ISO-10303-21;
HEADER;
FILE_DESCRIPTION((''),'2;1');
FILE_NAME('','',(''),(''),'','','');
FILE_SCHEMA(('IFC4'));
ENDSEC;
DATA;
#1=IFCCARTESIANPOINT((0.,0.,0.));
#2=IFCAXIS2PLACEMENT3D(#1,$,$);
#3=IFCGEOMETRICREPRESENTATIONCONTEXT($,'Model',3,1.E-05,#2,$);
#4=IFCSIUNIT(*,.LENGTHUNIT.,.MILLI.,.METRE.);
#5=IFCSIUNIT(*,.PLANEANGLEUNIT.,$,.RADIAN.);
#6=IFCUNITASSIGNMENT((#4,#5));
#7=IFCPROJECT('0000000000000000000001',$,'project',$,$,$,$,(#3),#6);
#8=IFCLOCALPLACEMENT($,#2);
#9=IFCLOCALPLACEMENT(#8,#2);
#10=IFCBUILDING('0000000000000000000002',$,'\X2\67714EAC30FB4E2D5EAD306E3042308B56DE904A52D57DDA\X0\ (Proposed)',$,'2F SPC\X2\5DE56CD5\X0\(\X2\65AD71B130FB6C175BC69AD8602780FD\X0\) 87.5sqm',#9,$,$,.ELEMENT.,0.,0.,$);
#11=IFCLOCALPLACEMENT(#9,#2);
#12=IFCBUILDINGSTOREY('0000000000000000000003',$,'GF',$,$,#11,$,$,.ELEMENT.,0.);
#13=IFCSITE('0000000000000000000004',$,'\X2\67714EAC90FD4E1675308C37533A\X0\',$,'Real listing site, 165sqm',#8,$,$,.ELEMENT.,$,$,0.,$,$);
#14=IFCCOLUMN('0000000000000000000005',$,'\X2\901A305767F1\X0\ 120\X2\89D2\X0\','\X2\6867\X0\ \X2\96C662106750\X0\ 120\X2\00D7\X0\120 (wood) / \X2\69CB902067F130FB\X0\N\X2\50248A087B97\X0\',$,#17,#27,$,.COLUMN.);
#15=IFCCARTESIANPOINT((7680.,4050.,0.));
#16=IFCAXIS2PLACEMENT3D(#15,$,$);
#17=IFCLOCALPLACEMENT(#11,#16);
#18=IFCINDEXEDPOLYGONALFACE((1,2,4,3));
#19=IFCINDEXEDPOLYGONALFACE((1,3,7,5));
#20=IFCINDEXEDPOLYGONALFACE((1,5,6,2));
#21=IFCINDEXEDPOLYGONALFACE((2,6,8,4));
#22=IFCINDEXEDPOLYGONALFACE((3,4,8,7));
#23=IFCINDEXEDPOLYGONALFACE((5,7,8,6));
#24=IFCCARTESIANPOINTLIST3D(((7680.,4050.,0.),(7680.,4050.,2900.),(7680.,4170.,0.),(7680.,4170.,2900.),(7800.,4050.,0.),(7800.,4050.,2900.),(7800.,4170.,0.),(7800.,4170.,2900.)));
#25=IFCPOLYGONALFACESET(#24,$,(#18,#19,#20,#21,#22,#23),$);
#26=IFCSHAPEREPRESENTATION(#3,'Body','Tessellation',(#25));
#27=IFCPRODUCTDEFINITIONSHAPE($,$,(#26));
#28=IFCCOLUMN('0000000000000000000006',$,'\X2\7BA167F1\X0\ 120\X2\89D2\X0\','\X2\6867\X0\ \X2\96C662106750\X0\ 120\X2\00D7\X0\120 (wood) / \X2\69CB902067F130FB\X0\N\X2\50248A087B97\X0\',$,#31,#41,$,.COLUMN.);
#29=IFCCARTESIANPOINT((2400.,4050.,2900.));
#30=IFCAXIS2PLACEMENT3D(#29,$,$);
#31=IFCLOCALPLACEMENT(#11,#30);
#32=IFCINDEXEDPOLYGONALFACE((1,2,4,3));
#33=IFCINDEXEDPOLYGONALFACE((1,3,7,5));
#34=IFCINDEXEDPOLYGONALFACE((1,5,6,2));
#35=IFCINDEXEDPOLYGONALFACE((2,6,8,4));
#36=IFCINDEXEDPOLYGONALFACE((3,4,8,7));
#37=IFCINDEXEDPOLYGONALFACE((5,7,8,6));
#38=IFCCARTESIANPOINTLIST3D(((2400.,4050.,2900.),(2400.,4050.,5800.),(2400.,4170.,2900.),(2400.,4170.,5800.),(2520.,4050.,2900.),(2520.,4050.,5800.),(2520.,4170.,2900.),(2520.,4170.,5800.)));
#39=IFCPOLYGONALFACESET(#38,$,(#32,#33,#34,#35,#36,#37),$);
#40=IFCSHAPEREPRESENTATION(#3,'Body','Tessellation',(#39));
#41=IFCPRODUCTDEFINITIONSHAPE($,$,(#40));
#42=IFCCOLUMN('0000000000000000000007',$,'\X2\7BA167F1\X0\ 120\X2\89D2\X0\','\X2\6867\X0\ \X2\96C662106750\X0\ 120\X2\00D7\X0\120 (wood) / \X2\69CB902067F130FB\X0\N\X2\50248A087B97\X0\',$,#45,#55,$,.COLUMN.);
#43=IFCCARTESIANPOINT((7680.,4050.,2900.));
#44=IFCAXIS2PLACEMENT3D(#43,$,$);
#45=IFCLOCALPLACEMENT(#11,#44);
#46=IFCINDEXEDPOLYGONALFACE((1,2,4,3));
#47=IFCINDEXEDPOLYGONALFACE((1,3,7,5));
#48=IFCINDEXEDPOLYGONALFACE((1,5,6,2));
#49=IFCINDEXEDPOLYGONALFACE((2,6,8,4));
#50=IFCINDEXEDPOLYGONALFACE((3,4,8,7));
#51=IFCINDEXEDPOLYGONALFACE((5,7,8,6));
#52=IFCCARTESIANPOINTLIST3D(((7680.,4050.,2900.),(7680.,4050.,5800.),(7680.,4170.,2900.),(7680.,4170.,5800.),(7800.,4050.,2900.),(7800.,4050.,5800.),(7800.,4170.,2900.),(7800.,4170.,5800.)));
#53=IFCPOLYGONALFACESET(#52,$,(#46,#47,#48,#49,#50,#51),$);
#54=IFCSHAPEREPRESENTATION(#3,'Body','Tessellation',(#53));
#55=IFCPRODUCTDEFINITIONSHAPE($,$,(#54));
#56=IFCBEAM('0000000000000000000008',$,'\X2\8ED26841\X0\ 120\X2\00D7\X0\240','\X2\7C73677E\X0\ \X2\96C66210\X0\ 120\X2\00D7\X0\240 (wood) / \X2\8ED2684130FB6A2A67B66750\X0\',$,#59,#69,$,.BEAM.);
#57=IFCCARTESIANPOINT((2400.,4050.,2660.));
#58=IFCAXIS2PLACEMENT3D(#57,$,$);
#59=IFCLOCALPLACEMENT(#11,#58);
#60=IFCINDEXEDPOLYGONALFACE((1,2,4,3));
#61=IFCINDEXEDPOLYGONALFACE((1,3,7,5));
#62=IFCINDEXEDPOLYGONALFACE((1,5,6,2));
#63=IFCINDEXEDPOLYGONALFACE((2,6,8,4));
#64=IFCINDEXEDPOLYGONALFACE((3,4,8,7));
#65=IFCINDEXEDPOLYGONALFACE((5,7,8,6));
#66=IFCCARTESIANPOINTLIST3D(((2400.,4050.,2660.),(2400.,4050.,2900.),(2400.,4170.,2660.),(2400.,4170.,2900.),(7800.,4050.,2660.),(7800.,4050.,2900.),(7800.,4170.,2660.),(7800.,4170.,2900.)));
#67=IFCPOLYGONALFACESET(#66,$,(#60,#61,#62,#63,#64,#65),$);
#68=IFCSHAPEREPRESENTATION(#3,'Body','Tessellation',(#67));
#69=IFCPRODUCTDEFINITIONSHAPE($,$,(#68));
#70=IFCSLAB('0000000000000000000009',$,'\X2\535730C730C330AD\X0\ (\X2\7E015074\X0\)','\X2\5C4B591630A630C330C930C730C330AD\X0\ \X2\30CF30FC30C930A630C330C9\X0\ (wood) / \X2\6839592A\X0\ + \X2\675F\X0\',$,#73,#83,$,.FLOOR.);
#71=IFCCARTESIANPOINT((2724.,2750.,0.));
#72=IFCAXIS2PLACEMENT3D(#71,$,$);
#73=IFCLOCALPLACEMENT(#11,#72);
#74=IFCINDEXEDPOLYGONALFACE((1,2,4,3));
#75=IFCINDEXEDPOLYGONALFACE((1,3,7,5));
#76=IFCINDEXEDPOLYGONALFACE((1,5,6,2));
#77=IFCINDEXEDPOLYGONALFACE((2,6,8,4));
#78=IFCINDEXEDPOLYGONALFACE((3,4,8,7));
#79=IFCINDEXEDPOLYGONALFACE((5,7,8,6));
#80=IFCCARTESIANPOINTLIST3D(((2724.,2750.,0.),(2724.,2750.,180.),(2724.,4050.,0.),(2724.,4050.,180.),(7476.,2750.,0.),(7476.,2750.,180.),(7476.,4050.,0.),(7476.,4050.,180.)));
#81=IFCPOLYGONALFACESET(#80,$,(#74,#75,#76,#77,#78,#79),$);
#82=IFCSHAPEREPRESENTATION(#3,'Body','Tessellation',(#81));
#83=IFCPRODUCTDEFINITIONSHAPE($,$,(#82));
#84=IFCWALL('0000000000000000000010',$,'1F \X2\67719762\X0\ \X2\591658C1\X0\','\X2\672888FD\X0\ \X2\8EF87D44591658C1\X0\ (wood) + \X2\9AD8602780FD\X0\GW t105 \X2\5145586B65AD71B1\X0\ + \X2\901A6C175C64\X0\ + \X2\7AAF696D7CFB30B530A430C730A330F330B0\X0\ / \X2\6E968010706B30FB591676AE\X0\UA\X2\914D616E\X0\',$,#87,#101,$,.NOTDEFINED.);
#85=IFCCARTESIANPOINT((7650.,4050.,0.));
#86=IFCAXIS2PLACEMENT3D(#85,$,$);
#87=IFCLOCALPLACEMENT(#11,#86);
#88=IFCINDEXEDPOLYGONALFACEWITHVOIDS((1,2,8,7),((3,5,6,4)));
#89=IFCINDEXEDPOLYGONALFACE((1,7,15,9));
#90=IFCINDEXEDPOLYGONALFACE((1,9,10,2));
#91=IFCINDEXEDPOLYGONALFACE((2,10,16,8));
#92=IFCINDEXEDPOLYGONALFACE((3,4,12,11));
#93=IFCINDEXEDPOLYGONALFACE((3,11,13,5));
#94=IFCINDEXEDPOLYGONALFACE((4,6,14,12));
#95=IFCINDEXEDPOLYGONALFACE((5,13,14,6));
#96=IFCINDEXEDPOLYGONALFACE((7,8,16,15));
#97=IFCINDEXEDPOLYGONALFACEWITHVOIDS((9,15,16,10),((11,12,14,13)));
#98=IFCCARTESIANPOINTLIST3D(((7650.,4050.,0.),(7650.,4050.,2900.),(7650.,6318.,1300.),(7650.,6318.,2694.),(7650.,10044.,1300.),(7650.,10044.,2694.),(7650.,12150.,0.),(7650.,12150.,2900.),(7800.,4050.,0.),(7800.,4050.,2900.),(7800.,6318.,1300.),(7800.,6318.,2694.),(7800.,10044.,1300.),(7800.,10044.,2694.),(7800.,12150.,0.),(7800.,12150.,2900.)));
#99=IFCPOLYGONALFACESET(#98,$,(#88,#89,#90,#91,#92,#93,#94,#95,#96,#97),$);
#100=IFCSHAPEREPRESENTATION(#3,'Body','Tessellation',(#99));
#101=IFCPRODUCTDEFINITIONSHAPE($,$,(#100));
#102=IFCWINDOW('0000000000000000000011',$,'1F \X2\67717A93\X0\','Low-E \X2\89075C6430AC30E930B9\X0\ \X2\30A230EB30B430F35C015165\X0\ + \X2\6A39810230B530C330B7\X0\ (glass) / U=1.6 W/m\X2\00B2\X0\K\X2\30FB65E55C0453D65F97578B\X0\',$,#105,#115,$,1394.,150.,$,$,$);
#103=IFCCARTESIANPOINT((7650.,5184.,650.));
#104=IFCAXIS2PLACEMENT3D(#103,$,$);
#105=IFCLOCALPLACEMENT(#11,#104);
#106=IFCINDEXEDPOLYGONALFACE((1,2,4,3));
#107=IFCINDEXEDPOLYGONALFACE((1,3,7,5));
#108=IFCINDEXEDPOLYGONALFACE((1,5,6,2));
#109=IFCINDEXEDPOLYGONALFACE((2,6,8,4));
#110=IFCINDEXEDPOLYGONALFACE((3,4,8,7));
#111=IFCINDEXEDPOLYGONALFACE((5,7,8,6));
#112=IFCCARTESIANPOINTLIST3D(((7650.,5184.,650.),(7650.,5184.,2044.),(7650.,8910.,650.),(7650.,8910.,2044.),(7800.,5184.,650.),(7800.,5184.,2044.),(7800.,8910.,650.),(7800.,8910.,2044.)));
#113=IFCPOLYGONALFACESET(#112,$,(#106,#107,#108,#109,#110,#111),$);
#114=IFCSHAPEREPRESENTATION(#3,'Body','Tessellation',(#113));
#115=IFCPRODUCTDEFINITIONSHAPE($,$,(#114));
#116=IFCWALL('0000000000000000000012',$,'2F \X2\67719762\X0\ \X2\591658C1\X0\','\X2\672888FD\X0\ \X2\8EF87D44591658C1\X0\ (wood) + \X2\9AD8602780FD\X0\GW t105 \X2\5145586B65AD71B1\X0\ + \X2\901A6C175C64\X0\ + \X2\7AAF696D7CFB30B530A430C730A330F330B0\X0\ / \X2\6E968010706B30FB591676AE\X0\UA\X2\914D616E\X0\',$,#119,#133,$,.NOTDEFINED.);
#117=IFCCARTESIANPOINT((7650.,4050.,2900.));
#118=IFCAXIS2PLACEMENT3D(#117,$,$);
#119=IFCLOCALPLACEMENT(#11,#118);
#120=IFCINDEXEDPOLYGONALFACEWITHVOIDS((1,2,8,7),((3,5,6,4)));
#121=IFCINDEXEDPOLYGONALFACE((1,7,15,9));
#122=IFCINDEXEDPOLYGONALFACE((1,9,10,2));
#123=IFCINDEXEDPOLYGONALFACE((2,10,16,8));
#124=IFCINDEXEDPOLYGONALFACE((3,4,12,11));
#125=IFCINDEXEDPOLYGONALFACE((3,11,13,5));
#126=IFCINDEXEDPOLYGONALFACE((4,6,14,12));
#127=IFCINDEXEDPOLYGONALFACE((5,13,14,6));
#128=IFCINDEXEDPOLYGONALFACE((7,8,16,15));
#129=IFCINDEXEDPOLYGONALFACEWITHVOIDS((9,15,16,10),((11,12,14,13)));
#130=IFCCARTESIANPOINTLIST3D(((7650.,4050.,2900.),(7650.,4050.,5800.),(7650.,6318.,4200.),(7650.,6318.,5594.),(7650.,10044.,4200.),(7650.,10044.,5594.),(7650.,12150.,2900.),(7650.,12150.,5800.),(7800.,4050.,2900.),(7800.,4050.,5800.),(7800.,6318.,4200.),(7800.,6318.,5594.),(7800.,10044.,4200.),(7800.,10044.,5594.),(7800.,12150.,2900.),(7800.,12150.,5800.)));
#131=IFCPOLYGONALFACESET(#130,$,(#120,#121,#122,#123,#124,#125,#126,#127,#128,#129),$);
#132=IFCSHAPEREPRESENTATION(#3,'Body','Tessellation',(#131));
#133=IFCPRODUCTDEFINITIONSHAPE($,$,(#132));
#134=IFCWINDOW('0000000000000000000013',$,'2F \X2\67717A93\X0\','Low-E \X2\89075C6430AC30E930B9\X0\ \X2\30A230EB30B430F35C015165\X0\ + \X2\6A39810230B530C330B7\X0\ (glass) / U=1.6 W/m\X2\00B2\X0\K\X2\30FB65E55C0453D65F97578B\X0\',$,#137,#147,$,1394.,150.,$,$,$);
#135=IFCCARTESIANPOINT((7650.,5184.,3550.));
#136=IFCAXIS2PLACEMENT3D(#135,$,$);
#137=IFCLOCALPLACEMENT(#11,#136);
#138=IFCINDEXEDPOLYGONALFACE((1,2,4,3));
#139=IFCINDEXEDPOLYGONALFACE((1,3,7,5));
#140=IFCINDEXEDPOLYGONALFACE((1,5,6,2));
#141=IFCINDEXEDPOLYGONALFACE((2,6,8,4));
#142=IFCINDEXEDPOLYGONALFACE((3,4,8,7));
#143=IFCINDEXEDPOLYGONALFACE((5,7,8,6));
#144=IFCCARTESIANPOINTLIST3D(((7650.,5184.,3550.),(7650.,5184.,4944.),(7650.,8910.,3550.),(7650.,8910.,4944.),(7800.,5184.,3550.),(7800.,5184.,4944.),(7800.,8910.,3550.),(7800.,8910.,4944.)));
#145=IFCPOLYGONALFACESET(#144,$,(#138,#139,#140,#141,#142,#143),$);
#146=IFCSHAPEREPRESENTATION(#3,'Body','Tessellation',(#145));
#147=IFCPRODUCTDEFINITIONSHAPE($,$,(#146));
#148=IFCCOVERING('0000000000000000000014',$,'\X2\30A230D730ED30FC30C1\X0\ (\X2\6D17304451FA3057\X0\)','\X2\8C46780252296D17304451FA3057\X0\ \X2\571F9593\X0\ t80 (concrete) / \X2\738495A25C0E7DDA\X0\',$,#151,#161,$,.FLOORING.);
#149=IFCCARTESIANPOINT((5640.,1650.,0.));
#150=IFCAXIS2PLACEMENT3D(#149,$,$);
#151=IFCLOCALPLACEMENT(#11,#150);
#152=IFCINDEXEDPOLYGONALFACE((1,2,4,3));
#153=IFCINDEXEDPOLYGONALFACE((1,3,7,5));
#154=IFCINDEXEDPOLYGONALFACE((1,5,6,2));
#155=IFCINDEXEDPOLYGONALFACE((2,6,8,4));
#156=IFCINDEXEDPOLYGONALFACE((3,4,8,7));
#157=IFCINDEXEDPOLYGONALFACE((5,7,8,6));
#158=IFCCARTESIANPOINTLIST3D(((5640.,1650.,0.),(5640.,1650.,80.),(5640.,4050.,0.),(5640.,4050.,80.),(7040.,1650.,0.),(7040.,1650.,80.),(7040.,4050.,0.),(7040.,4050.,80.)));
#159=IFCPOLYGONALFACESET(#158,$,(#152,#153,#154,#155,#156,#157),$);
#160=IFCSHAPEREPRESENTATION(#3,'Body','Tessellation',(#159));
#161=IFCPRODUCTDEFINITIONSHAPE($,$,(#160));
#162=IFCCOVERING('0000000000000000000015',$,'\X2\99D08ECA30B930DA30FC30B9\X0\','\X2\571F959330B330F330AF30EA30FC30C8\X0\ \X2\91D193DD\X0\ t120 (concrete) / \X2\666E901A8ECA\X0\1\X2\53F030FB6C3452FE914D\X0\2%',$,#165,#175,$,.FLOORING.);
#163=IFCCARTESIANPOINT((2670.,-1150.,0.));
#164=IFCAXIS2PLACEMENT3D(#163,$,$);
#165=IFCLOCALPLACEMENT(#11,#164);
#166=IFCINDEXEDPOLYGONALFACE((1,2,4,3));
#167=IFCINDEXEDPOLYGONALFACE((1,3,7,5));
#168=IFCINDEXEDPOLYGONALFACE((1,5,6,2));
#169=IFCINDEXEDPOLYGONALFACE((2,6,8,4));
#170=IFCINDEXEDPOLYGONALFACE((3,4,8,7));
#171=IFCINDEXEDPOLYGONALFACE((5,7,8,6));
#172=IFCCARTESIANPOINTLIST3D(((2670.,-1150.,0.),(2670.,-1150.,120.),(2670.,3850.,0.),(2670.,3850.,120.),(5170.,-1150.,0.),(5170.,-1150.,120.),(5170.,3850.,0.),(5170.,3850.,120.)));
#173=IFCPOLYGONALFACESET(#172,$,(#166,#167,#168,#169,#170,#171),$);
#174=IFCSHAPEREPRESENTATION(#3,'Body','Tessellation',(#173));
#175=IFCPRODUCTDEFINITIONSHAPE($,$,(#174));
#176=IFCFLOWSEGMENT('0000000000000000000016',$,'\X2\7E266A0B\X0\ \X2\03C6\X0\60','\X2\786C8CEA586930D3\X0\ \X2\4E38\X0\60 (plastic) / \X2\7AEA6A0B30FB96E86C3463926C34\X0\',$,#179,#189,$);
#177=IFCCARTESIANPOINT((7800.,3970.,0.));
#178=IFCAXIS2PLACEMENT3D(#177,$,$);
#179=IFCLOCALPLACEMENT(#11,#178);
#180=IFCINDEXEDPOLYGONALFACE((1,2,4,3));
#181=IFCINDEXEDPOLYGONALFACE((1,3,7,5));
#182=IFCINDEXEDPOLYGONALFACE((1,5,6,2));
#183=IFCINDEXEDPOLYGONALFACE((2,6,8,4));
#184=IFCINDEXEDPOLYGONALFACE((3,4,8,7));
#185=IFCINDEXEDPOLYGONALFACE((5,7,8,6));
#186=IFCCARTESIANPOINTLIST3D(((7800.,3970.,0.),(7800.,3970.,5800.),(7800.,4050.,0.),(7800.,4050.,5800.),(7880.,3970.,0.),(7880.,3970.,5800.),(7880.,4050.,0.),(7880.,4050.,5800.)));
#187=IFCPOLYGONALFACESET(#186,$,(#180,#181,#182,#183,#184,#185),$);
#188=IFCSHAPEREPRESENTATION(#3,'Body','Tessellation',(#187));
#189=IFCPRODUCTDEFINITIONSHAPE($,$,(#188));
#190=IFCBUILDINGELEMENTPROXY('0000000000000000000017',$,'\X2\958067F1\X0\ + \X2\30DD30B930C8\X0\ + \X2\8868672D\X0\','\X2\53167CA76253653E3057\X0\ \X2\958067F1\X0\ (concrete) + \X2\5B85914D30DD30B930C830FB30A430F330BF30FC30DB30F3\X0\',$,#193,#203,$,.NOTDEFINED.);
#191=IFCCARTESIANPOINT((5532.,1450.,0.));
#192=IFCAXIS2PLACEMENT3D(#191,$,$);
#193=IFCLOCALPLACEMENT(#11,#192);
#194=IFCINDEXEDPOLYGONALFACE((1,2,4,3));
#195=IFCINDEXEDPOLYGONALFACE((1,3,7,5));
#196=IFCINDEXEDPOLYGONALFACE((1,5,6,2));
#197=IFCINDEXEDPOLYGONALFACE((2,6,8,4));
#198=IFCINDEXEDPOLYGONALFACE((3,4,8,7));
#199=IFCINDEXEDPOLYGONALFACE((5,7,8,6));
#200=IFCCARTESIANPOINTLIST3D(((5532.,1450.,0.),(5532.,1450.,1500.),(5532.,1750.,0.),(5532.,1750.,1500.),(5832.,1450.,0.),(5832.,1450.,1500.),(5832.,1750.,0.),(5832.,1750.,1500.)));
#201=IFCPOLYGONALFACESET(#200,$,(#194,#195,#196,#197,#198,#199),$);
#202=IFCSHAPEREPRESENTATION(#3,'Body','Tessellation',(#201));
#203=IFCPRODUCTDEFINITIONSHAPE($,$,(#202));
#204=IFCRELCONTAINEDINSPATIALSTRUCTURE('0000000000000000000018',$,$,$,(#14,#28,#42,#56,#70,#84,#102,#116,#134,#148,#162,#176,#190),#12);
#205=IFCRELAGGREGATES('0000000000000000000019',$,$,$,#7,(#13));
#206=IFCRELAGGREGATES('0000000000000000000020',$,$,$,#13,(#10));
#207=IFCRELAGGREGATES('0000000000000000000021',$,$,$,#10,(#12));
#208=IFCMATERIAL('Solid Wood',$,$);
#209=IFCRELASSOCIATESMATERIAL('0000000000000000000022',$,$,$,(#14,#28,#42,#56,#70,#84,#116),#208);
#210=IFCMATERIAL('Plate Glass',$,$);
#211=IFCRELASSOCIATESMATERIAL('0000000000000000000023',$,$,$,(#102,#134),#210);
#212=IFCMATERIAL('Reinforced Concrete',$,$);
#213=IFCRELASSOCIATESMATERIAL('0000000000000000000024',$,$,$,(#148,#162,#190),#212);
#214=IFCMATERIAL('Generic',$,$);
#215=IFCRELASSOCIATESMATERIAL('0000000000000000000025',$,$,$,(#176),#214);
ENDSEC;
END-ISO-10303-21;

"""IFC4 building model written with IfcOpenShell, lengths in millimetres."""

from ifc_helpers import new_model, si_unit, frame, frame_2d, origin, place, context, project, spatial, rectangle, extrude, material, element, fill, save


model = new_model("IFC4")

# Units and contexts
model_context = context("Model", 3, precision=1e-05, world=origin())
ifc_project = project(units=[si_unit("LENGTHUNIT", "METRE", prefix="MILLI"), si_unit("PLANEANGLEUNIT", "RADIAN")], contexts=[model_context])

# Site, building, storey
site_placement = place(None, origin())
site = spatial("IfcSite", under=ifc_project, at=site_placement, Name="東京都世田谷区", ObjectType="Real listing site, 165sqm", CompositionType="ELEMENT", RefElevation=0.0)
building_placement = place(site_placement, origin())
building = spatial("IfcBuilding", under=site, at=building_placement, Name="東京・中庭のある回遊動線 (Proposed)", ObjectType="2F SPC工法(断熱・気密高性能) 87.5sqm", CompositionType="ELEMENT", ElevationOfRefHeight=0.0, ElevationOfTerrain=0.0)
storey_placement = place(building_placement, origin())
storey = spatial("IfcBuildingStorey", under=building, at=storey_placement, Name="GF", CompositionType="ELEMENT", Elevation=0.0)

# Columns
ifc_material_1 = material(Name="Solid Wood")
column_1_placement = place(storey_placement, frame((7680.0, 4050.0, 0.0)))
element("IfcColumn", 1, at=column_1_placement, inside=storey, material=ifc_material_1, Name="通し柱 120角", Description="桧 集成材 120×120 (wood) / 構造柱・N値計算", PredefinedType="COLUMN", context=model_context, shape_type="SweptSolid", body=[
    extrude(rectangle(XDim=120.0, YDim=120.0, at=frame_2d((60.0, 60.0))), frame((7680.0, 4050.0, 0.0)), (0.0, 0.0, 1.0), 2900.0),
])
column_2_placement = place(storey_placement, frame((2400.0, 4050.0, 2900.0)))
element("IfcColumn", 2, at=column_2_placement, inside=storey, material=ifc_material_1, Name="管柱 120角", Description="桧 集成材 120×120 (wood) / 構造柱・N値計算", PredefinedType="COLUMN", context=model_context, shape_type="SweptSolid", body=[
    extrude(rectangle(XDim=120.0, YDim=120.0, at=frame_2d((60.0, 60.0))), frame((2400.0, 4050.0, 2900.0)), (0.0, 0.0, 1.0), 2900.0),
])
column_3_placement = place(storey_placement, frame((7680.0, 4050.0, 2900.0)))
element("IfcColumn", 3, at=column_3_placement, inside=storey, material=ifc_material_1, Name="管柱 120角", Description="桧 集成材 120×120 (wood) / 構造柱・N値計算", PredefinedType="COLUMN", context=model_context, shape_type="SweptSolid", body=[
    extrude(rectangle(XDim=120.0, YDim=120.0, at=frame_2d((60.0, 60.0))), frame((7680.0, 4050.0, 2900.0)), (0.0, 0.0, 1.0), 2900.0),
])

# Beam
beam_1_placement = place(storey_placement, frame((2400.0, 4050.0, 2660.0)))
element("IfcBeam", 4, at=beam_1_placement, inside=storey, material=ifc_material_1, Name="軒桁 120×240", Description="米松 集成 120×240 (wood) / 軒桁・横架材", PredefinedType="BEAM", context=model_context, shape_type="SweptSolid", body=[
    extrude(rectangle(XDim=5400.0, YDim=120.0, at=frame_2d((2700.0, 60.0))), frame((2400.0, 4050.0, 2660.0)), (0.0, 0.0, 1.0), 240.0),
])

# Slab
slab_placement = place(storey_placement, frame((2724.0, 2750.0, 0.0)))
element("IfcSlab", 5, at=slab_placement, inside=storey, material=ifc_material_1, Name="南デッキ (縁側)", Description="屋外ウッドデッキ ハードウッド (wood) / 根太 + 束", PredefinedType="FLOOR", context=model_context, shape_type="SweptSolid", body=[
    extrude(rectangle(XDim=4752.0, YDim=1300.0, at=frame_2d((2376.0, 650.0))), frame((2724.0, 2750.0, 0.0)), (0.0, 0.0, 1.0), 180.0),
])

# Walls, openings, windows
wall_1_placement = place(storey_placement, frame((7650.0, 4050.0, 0.0)))
wall_1 = element("IfcWall", 6, at=wall_1_placement, inside=storey, material=ifc_material_1, Name="1F 東面 外壁", Description="木製 軸組外壁 (wood) + 高性能GW t105 充填断熱 + 通気層 + 窯業系サイディング / 準耐火・外皮UA配慮", PredefinedType="NOTDEFINED", context=model_context, shape_type="SweptSolid", body=[
    extrude(rectangle(XDim=150.0, YDim=8100.0, at=frame_2d((75.0, 4050.0))), frame((7650.0, 4050.0, 0.0)), (0.0, 0.0, 1.0), 2900.0),
])
opening_1_placement = place(storey_placement, frame((7650.0, 5184.0, 650.0)))
opening_1 = element("IfcOpeningElement", 7, at=opening_1_placement, cuts=wall_1, PredefinedType="NOTDEFINED", context=model_context, shape_type="SweptSolid", body=[
    extrude(rectangle(XDim=150.0, YDim=3726.0, at=frame_2d((75.0, 1863.0))), frame((7650.0, 5184.0, 650.0)), (0.0, 0.0, 1.0), 1394.0),
])
ifc_material_2 = material(Name="Plate Glass")
window_1_placement = place(storey_placement, frame((7650.0, 5184.0, 650.0)))
window_1 = element("IfcWindow", 8, at=window_1_placement, inside=storey, material=ifc_material_2, Name="1F 東窓", Description="Low-E 複層ガラス アルゴン封入 + 樹脂サッシ (glass) / U=1.6 W/m²K・日射取得型", OverallHeight=1394.0, OverallWidth=150.0, context=model_context, shape_type="SweptSolid", body=[
    extrude(rectangle(XDim=150.0, YDim=3726.0, at=frame_2d((75.0, 1863.0))), frame((7650.0, 5184.0, 650.0)), (0.0, 0.0, 1.0), 1394.0),
])
fill(opening_1, window_1)
wall_2_placement = place(storey_placement, frame((7650.0, 4050.0, 2900.0)))
wall_2 = element("IfcWall", 9, at=wall_2_placement, inside=storey, material=ifc_material_1, Name="2F 東面 外壁", Description="木製 軸組外壁 (wood) + 高性能GW t105 充填断熱 + 通気層 + 窯業系サイディング / 準耐火・外皮UA配慮", PredefinedType="NOTDEFINED", context=model_context, shape_type="SweptSolid", body=[
    extrude(rectangle(XDim=150.0, YDim=8100.0, at=frame_2d((75.0, 4050.0))), frame((7650.0, 4050.0, 2900.0)), (0.0, 0.0, 1.0), 2900.0),
])
opening_2_placement = place(storey_placement, frame((7650.0, 5184.0, 3550.0)))
opening_2 = element("IfcOpeningElement", 10, at=opening_2_placement, cuts=wall_2, PredefinedType="NOTDEFINED", context=model_context, shape_type="SweptSolid", body=[
    extrude(rectangle(XDim=150.0, YDim=3726.0, at=frame_2d((75.0, 1863.0))), frame((7650.0, 5184.0, 3550.0)), (0.0, 0.0, 1.0), 1394.0),
])
window_2_placement = place(storey_placement, frame((7650.0, 5184.0, 3550.0)))
window_2 = element("IfcWindow", 11, at=window_2_placement, inside=storey, material=ifc_material_2, Name="2F 東窓", Description="Low-E 複層ガラス アルゴン封入 + 樹脂サッシ (glass) / U=1.6 W/m²K・日射取得型", OverallHeight=1394.0, OverallWidth=150.0, context=model_context, shape_type="SweptSolid", body=[
    extrude(rectangle(XDim=150.0, YDim=3726.0, at=frame_2d((75.0, 1863.0))), frame((7650.0, 5184.0, 3550.0)), (0.0, 0.0, 1.0), 1394.0),
])
fill(opening_2, window_2)

# Coverings
ifc_material_3 = material(Name="Reinforced Concrete")
covering_1_placement = place(storey_placement, frame((5640.0, 1650.0, 0.0)))
element("IfcCovering", 12, at=covering_1_placement, inside=storey, material=ifc_material_3, Name="アプローチ (洗い出し)", Description="豆砂利洗い出し 土間 t80 (concrete) / 玄関導線", PredefinedType="FLOORING", context=model_context, shape_type="SweptSolid", body=[
    extrude(rectangle(XDim=1400.0, YDim=2400.0, at=frame_2d((700.0, 1200.0))), frame((5640.0, 1650.0, 0.0)), (0.0, 0.0, 1.0), 80.0),
])
covering_2_placement = place(storey_placement, frame((2670.0, -1150.0, 0.0)))
element("IfcCovering", 13, at=covering_2_placement, inside=storey, material=ifc_material_3, Name="駐車スペース", Description="土間コンクリート 金鏝 t120 (concrete) / 普通車1台・水勾配2%", PredefinedType="FLOORING", context=model_context, shape_type="SweptSolid", body=[
    extrude(rectangle(XDim=2500.0, YDim=5000.0, at=frame_2d((1250.0, 2500.0))), frame((2670.0, -1150.0, 0.0)), (0.0, 0.0, 1.0), 120.0),
])

# Flow segment
ifc_material_4 = material(Name="Generic")
flow_segment_placement = place(storey_placement, frame((7800.0, 3970.0, 0.0)))
element("IfcFlowSegment", 14, at=flow_segment_placement, inside=storey, material=ifc_material_4, Name="縦樋 φ60", Description="硬質塩ビ 丸60 (plastic) / 竪樋・雨水排水", context=model_context, shape_type="SweptSolid", body=[
    extrude(rectangle(XDim=80.0, YDim=80.0, at=frame_2d((40.0, 40.0))), frame((7800.0, 3970.0, 0.0)), (0.0, 0.0, 1.0), 5800.0),
])

# Building element proxy
proxy_placement = place(storey_placement, frame((5532.0, 1450.0, 0.0)))
element("IfcBuildingElementProxy", 15, at=proxy_placement, inside=storey, material=ifc_material_3, Name="門柱 + ポスト + 表札", Description="化粧打放し 門柱 (concrete) + 宅配ポスト・インターホン", PredefinedType="NOTDEFINED", context=model_context, shape_type="SweptSolid", body=[
    extrude(rectangle(XDim=300.0, YDim=300.0, at=frame_2d((150.0, 150.0))), frame((5532.0, 1450.0, 0.0)), (0.0, 0.0, 1.0), 1500.0),
])

save(model, "model.ifc")
